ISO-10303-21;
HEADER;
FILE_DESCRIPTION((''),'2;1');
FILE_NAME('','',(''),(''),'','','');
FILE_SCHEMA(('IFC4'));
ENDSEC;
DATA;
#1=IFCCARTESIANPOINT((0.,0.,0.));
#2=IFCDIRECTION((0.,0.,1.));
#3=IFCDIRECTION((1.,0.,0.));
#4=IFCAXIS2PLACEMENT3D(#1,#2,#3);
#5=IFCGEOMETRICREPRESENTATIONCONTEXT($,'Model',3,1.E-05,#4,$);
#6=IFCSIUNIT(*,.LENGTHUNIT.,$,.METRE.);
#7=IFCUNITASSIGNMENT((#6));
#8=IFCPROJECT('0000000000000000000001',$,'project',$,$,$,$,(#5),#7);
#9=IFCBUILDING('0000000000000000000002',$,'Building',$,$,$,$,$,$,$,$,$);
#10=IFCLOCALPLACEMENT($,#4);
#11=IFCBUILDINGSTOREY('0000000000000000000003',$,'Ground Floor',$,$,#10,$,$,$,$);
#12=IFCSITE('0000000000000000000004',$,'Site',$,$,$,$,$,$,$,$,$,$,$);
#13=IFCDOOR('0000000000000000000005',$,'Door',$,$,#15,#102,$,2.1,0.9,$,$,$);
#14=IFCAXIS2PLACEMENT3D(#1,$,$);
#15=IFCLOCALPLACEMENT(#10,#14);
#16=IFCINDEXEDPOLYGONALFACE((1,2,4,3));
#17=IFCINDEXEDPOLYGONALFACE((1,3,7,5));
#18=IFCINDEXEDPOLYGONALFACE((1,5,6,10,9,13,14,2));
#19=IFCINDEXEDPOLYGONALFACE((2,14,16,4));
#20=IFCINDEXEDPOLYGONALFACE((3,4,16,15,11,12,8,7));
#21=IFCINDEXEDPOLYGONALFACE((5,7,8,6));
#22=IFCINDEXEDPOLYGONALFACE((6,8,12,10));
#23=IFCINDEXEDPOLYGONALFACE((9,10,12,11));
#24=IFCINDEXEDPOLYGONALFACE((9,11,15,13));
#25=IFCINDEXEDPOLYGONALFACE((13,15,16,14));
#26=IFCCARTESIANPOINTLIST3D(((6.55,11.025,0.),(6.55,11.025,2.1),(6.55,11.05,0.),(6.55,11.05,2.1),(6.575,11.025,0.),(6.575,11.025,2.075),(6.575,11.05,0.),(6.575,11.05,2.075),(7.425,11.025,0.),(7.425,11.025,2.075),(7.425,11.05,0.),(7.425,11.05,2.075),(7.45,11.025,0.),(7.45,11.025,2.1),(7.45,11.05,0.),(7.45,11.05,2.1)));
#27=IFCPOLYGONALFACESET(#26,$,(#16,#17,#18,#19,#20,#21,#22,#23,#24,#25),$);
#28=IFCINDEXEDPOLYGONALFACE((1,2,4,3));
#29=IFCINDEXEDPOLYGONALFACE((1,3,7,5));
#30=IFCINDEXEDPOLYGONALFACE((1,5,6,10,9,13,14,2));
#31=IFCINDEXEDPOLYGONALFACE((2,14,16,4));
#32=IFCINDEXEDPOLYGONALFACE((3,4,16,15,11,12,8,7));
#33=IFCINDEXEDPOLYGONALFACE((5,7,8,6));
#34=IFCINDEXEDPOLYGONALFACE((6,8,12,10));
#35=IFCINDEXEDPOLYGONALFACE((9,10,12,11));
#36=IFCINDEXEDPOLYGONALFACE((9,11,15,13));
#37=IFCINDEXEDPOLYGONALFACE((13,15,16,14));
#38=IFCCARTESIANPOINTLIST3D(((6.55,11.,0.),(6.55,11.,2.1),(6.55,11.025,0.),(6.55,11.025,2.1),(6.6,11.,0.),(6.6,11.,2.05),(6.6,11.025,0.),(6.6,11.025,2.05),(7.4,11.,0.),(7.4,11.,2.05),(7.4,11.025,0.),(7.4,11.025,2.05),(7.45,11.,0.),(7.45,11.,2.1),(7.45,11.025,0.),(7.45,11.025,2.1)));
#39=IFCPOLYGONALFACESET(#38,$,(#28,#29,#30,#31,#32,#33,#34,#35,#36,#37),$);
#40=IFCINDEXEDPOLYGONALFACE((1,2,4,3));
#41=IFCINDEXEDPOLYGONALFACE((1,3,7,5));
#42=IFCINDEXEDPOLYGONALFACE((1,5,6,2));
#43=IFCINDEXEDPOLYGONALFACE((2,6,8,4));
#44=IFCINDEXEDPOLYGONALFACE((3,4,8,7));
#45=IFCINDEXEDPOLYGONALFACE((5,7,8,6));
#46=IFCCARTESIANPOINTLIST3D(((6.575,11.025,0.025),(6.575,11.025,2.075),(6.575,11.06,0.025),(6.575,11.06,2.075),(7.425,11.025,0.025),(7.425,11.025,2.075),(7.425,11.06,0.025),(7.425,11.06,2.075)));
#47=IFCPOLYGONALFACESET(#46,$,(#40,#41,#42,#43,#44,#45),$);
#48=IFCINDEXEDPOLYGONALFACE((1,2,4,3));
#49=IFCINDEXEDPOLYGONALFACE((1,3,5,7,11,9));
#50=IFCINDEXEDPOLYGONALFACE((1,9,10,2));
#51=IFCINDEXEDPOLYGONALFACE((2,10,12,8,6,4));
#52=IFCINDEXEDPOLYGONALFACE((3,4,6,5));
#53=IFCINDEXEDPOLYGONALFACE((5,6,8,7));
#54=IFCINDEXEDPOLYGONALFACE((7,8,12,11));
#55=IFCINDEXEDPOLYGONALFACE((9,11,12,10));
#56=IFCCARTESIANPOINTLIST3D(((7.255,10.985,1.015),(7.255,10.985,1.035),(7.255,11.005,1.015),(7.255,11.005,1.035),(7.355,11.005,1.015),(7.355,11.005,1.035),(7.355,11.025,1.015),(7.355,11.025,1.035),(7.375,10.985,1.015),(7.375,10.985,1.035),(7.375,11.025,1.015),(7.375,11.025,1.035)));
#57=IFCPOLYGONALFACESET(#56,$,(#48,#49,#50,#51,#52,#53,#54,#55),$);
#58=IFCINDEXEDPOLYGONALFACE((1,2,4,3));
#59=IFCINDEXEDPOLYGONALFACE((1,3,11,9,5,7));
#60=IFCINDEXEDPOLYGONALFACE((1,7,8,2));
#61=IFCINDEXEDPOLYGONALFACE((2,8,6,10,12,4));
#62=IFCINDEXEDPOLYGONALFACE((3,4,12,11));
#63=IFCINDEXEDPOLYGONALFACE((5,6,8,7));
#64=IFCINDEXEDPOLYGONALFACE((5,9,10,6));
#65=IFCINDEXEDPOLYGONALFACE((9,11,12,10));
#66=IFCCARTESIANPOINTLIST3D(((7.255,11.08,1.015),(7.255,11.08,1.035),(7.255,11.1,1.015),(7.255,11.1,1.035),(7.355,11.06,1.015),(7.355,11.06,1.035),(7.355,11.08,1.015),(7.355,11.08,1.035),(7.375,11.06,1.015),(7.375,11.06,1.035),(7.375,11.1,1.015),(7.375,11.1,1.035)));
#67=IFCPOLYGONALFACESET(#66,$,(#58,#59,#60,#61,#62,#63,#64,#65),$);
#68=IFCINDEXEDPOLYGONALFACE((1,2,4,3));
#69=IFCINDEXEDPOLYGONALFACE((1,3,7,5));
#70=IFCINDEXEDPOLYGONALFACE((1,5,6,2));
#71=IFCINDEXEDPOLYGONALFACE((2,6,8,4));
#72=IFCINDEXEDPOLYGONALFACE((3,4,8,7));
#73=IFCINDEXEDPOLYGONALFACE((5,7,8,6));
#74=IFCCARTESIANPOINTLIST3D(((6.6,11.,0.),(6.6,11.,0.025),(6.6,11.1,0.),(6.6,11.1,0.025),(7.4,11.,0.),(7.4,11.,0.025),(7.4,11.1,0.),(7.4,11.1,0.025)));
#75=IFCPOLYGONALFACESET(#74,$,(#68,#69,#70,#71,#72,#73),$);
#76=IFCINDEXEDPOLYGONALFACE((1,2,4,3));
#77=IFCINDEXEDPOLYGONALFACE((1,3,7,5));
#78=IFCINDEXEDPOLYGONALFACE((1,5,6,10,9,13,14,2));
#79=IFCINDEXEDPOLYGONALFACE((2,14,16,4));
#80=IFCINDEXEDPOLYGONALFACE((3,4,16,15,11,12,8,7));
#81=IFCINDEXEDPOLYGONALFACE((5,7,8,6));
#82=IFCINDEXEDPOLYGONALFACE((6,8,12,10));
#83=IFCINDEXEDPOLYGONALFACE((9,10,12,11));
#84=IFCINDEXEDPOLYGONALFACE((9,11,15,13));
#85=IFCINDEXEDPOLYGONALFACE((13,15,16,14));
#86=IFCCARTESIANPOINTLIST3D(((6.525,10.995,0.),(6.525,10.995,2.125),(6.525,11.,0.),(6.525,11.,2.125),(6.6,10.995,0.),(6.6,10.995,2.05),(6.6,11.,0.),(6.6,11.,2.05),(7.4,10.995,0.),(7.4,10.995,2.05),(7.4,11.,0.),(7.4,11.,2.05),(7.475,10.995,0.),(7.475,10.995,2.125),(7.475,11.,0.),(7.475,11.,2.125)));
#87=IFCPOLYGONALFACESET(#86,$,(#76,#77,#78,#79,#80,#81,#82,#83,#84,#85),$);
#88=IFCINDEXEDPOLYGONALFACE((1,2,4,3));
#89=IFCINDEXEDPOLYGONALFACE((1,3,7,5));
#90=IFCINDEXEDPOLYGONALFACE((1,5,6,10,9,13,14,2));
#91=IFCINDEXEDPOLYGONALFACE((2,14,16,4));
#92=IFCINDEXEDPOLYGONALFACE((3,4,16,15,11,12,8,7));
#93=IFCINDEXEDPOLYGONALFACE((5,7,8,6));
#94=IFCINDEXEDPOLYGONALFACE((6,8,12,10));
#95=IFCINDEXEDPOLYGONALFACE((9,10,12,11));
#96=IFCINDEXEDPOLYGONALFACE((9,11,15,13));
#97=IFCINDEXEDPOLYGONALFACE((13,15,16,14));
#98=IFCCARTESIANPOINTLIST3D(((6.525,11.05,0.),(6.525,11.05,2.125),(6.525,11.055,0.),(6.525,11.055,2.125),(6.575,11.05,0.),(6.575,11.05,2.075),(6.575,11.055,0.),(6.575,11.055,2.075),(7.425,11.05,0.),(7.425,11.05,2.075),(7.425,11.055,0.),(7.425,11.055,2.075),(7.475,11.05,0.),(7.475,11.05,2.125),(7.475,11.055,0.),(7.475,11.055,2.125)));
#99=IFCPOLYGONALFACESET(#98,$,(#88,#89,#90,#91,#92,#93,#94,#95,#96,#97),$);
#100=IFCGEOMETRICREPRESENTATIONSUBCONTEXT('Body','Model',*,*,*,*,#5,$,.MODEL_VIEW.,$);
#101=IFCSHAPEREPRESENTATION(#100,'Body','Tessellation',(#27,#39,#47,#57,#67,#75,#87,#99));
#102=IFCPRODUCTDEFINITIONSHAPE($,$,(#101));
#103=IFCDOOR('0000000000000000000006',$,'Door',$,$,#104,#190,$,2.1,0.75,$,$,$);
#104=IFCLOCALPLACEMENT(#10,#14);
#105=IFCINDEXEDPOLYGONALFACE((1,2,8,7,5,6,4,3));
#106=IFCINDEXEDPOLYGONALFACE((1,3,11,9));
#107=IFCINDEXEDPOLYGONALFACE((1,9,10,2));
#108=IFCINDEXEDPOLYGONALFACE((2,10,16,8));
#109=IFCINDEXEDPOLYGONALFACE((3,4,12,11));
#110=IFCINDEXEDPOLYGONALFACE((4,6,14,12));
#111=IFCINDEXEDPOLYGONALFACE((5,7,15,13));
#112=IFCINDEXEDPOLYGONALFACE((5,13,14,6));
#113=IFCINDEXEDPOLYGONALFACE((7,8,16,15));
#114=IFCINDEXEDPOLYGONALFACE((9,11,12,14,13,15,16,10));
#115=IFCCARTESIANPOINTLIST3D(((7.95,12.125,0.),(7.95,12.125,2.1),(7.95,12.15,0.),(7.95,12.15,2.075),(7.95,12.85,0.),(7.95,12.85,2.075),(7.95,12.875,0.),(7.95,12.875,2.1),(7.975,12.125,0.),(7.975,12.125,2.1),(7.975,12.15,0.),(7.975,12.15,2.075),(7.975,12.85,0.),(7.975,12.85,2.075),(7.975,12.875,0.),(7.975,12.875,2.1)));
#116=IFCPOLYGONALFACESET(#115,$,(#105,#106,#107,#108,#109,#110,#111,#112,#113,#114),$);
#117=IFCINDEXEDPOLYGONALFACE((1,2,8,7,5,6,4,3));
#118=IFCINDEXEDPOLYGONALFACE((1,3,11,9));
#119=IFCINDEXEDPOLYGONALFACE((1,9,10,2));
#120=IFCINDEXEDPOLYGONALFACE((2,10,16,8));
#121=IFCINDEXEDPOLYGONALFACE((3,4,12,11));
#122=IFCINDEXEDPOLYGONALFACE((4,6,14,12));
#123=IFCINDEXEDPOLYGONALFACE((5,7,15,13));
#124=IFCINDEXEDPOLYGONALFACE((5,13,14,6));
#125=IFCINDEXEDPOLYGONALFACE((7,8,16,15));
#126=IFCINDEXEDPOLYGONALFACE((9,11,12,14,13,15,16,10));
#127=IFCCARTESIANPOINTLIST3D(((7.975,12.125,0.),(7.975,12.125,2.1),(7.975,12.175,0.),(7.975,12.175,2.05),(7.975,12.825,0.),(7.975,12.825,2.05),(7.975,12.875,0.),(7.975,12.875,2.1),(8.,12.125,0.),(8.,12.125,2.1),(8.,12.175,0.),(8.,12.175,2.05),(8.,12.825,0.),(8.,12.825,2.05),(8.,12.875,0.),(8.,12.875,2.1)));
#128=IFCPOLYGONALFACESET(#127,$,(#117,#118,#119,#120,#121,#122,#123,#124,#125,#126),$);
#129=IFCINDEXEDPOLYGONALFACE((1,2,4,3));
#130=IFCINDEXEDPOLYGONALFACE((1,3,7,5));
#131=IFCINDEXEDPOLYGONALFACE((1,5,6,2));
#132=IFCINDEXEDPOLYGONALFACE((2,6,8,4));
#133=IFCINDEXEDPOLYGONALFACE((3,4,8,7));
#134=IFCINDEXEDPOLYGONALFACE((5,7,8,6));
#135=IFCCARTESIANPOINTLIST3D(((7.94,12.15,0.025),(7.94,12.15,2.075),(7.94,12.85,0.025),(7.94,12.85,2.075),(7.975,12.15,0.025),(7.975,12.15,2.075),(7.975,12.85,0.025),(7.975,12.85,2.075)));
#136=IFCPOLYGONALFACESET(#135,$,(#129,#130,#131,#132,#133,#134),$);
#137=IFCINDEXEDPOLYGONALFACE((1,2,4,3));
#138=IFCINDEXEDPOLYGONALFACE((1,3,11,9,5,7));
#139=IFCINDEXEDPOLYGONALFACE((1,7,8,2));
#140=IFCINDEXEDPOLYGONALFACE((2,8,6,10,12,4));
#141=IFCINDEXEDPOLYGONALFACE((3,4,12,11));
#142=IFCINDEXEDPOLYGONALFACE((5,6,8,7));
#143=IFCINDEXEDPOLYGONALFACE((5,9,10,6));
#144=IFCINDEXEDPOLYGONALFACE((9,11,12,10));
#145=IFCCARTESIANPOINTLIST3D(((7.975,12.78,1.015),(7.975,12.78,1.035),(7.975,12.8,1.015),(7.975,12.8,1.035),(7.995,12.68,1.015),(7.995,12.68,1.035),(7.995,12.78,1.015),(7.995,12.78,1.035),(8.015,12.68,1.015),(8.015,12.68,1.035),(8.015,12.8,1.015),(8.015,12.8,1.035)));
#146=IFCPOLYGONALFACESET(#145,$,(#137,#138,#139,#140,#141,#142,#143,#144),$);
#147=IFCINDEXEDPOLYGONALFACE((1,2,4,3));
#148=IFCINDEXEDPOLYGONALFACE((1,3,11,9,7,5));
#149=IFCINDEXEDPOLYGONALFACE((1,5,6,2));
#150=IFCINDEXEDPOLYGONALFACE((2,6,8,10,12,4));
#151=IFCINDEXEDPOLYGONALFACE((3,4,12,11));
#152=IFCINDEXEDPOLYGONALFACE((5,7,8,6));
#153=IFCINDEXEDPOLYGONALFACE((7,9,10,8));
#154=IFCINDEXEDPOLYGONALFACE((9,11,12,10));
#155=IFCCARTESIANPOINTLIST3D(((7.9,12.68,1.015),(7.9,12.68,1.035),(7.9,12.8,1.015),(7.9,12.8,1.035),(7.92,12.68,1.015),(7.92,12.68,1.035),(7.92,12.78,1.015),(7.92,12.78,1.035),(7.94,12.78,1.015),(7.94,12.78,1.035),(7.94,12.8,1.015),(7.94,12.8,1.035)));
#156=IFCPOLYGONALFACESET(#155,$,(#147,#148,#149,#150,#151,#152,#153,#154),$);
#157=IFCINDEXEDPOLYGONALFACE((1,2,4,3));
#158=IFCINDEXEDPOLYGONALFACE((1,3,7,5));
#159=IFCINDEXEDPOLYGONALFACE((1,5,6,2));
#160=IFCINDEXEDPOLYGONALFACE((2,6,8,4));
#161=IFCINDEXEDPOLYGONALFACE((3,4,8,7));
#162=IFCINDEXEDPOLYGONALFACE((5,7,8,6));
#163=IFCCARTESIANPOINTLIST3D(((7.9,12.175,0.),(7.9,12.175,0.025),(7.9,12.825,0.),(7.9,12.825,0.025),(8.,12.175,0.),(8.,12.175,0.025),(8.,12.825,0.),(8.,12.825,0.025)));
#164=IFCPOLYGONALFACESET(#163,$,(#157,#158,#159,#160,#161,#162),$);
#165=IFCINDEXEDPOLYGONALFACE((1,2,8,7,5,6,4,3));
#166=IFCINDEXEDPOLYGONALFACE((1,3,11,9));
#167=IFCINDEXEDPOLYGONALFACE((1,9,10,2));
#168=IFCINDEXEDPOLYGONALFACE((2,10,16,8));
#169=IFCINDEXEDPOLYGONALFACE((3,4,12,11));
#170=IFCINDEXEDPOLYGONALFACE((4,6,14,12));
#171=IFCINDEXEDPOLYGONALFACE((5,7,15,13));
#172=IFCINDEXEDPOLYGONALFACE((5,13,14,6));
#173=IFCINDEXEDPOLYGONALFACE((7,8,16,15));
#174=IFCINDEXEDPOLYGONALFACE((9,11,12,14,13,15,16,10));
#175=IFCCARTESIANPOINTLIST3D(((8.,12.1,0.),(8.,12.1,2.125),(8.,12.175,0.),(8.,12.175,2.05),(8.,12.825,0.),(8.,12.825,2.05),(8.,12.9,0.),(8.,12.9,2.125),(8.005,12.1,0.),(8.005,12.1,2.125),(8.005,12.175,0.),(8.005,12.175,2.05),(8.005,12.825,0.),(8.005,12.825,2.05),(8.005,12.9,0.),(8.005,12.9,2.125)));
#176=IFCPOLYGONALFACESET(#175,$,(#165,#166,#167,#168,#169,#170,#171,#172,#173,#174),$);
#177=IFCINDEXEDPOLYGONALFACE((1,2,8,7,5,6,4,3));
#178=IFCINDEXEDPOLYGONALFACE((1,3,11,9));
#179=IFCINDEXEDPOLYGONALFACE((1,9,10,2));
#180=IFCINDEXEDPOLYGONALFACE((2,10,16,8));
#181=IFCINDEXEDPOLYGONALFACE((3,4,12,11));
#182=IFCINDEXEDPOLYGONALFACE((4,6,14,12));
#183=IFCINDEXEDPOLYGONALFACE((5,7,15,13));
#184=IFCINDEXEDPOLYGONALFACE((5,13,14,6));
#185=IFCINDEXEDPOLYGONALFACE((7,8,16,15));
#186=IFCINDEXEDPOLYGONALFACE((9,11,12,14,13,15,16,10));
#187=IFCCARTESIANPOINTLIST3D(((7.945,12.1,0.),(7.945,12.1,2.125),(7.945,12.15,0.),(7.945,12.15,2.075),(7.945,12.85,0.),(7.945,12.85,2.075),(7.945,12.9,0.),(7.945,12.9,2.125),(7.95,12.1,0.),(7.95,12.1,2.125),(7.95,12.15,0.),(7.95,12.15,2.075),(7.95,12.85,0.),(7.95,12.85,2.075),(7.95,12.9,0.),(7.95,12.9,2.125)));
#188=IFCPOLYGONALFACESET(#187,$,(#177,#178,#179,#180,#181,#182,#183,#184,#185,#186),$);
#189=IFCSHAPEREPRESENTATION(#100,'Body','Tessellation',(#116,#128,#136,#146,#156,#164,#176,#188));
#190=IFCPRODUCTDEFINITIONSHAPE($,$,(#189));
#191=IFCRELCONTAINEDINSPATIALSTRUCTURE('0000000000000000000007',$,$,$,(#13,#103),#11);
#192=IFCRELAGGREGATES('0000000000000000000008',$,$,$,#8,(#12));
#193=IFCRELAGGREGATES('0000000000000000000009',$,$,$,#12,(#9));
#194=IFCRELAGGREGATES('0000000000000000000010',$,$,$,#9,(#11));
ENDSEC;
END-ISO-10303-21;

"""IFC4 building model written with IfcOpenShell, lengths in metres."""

from ifc_helpers import new_model, si_unit, frame, origin_with_axes, place, context, subcontext, project, spatial, line, indexed_curve, outline, extrude, element, save


model = new_model("IFC4")

# Units and contexts
model_context = context("Model", 3, precision=1e-05, world=origin_with_axes())
body_context = subcontext(model_context, "Body", "Model", "MODEL_VIEW")
ifc_project = project(units=[si_unit("LENGTHUNIT", "METRE")], contexts=[model_context])

# Site, building, storey
site = spatial("IfcSite", under=ifc_project, Name="Site")
building = spatial("IfcBuilding", under=site, Name="Building")
storey_placement = place(None, origin_with_axes())
storey = spatial("IfcBuildingStorey", under=building, at=storey_placement, Name="Ground Floor")

# Doors
door_1_placement = place(storey_placement, frame((6.55, 11.0, 0.0), z_axis=(0.0, 0.0, 1.0), x_axis=(1.0, 0.0, 0.0)))
element("IfcDoor", 1, at=door_1_placement, inside=storey, Name="Door", OverallHeight=2.1, OverallWidth=0.9, context=body_context, shape_type="SweptSolid", body=[
    extrude(outline(indexed_curve([(0.0, 0.0), (0.0, 2.1), (0.9, 2.1), (0.9, 0.0), (0.875, 0.0), (0.875, 2.075), (0.025, 2.075), (0.025, 0.0)], segments=[line(1, 2, 3, 4, 5, 6, 7, 8, 1)])), frame((0.0, 0.025, 0.0), z_axis=(0.0, -1.0, 0.0), x_axis=(1.0, 0.0, 0.0)), (0.0, 0.0, -1.0), 0.025),
    extrude(outline(indexed_curve([(0.0, 0.0), (0.0, 2.1), (0.9, 2.1), (0.9, 0.0), (0.85, 0.0), (0.85, 2.05), (0.05, 2.05), (0.05, 0.0)], segments=[line(1, 2, 3, 4, 5, 6, 7, 8, 1)])), frame((0.0, 0.0, 0.0), z_axis=(0.0, -1.0, 0.0), x_axis=(1.0, 0.0, 0.0)), (0.0, 0.0, -1.0), 0.025),
    extrude(outline(indexed_curve([(0.0, 0.0), (0.85, 0.0), (0.85, 0.035), (0.0, 0.035)], segments=[line(1, 2, 3, 4, 1)])), frame((0.025, 0.025, 0.025), z_axis=(0.0, 0.0, 1.0), x_axis=(1.0, 0.0, 0.0)), (0.0, 0.0, 1.0), 2.05),
    extrude(outline(indexed_curve([(0.0, 0.0), (0.0, -0.04), (-0.12, -0.04), (-0.12, -0.02), (-0.02, -0.02), (-0.02, 0.0)], segments=[line(1, 2, 3, 4, 5, 6, 1)])), frame((0.825, 0.025, 1.015), z_axis=(0.0, 0.0, 1.0), x_axis=(1.0, 0.0, 0.0)), (0.0, 0.0, 1.0), 0.02),
    extrude(outline(indexed_curve([(0.0, 0.0), (0.0, 0.04), (-0.12, 0.04), (-0.12, 0.02), (-0.02, 0.02), (-0.02, 0.0)], segments=[line(1, 2, 3, 4, 5, 6, 1)])), frame((0.825, 0.06, 1.015), z_axis=(0.0, 0.0, 1.0), x_axis=(1.0, 0.0, 0.0)), (0.0, 0.0, 1.0), 0.02),
    extrude(outline(indexed_curve([(0.0, 0.0), (0.8, 0.0), (0.8, 0.1), (0.0, 0.1)], segments=[line(1, 2, 3, 4, 1)])), frame((0.05, 0.0, 0.0), z_axis=(0.0, 0.0, 1.0), x_axis=(1.0, 0.0, 0.0)), (0.0, 0.0, 1.0), 0.025),
    extrude(outline(indexed_curve([(0.0, 0.0), (0.0, 2.125), (0.95, 2.125), (0.95, 0.0), (0.875, 0.0), (0.875, 2.05), (0.075, 2.05), (0.075, 0.0)], segments=[line(1, 2, 3, 4, 5, 6, 7, 8, 1)])), frame((-0.025, -0.005, 0.0), z_axis=(0.0, -1.0, 0.0), x_axis=(1.0, 0.0, 0.0)), (0.0, 0.0, -1.0), 0.005),
    extrude(outline(indexed_curve([(0.0, 0.0), (0.0, 2.125), (0.95, 2.125), (0.95, 0.0), (0.9, 0.0), (0.9, 2.075), (0.05, 2.075), (0.05, 0.0)], segments=[line(1, 2, 3, 4, 5, 6, 7, 8, 1)])), frame((-0.025, 0.05, 0.0), z_axis=(0.0, -1.0, 0.0), x_axis=(1.0, 0.0, 0.0)), (0.0, 0.0, -1.0), 0.005),
])
door_2_placement = place(storey_placement, frame((8.0, 12.125, 0.0), z_axis=(0.0, 0.0, 1.0), x_axis=(0.0, 1.0, 0.0)))
element("IfcDoor", 2, at=door_2_placement, inside=storey, Name="Door", OverallHeight=2.1, OverallWidth=0.75, context=body_context, shape_type="SweptSolid", body=[
    extrude(outline(indexed_curve([(0.0, 0.0), (0.0, 2.1), (0.75, 2.1), (0.75, 0.0), (0.725, 0.0), (0.725, 2.075), (0.025, 2.075), (0.025, 0.0)], segments=[line(1, 2, 3, 4, 5, 6, 7, 8, 1)])), frame((0.0, 0.025, 0.0), z_axis=(0.0, -1.0, 0.0), x_axis=(1.0, 0.0, 0.0)), (0.0, 0.0, -1.0), 0.025),
    extrude(outline(indexed_curve([(0.0, 0.0), (0.0, 2.1), (0.75, 2.1), (0.75, 0.0), (0.7, 0.0), (0.7, 2.05), (0.05, 2.05), (0.05, 0.0)], segments=[line(1, 2, 3, 4, 5, 6, 7, 8, 1)])), frame((0.0, 0.0, 0.0), z_axis=(0.0, -1.0, 0.0), x_axis=(1.0, 0.0, 0.0)), (0.0, 0.0, -1.0), 0.025),
    extrude(outline(indexed_curve([(0.0, 0.0), (0.7, 0.0), (0.7, 0.035), (0.0, 0.035)], segments=[line(1, 2, 3, 4, 1)])), frame((0.025, 0.025, 0.025), z_axis=(0.0, 0.0, 1.0), x_axis=(1.0, 0.0, 0.0)), (0.0, 0.0, 1.0), 2.05),
    extrude(outline(indexed_curve([(0.0, 0.0), (0.0, -0.04), (-0.12, -0.04), (-0.12, -0.02), (-0.02, -0.02), (-0.02, 0.0)], segments=[line(1, 2, 3, 4, 5, 6, 1)])), frame((0.675, 0.025, 1.015), z_axis=(0.0, 0.0, 1.0), x_axis=(1.0, 0.0, 0.0)), (0.0, 0.0, 1.0), 0.02),
    extrude(outline(indexed_curve([(0.0, 0.0), (0.0, 0.04), (-0.12, 0.04), (-0.12, 0.02), (-0.02, 0.02), (-0.02, 0.0)], segments=[line(1, 2, 3, 4, 5, 6, 1)])), frame((0.675, 0.06, 1.015), z_axis=(0.0, 0.0, 1.0), x_axis=(1.0, 0.0, 0.0)), (0.0, 0.0, 1.0), 0.02),
    extrude(outline(indexed_curve([(0.0, 0.0), (0.65, 0.0), (0.65, 0.1), (0.0, 0.1)], segments=[line(1, 2, 3, 4, 1)])), frame((0.05, 0.0, 0.0), z_axis=(0.0, 0.0, 1.0), x_axis=(1.0, 0.0, 0.0)), (0.0, 0.0, 1.0), 0.025),
    extrude(outline(indexed_curve([(0.0, 0.0), (0.0, 2.125), (0.8, 2.125), (0.8, 0.0), (0.725, 0.0), (0.725, 2.05), (0.075, 2.05), (0.075, 0.0)], segments=[line(1, 2, 3, 4, 5, 6, 7, 8, 1)])), frame((-0.025, -0.005, 0.0), z_axis=(0.0, -1.0, 0.0), x_axis=(1.0, 0.0, 0.0)), (0.0, 0.0, -1.0), 0.005),
    extrude(outline(indexed_curve([(0.0, 0.0), (0.0, 2.125), (0.8, 2.125), (0.8, 0.0), (0.75, 0.0), (0.75, 2.075), (0.05, 2.075), (0.05, 0.0)], segments=[line(1, 2, 3, 4, 5, 6, 7, 8, 1)])), frame((-0.025, 0.05, 0.0), z_axis=(0.0, -1.0, 0.0), x_axis=(1.0, 0.0, 0.0)), (0.0, 0.0, -1.0), 0.005),
])

save(model, "model.ifc")
